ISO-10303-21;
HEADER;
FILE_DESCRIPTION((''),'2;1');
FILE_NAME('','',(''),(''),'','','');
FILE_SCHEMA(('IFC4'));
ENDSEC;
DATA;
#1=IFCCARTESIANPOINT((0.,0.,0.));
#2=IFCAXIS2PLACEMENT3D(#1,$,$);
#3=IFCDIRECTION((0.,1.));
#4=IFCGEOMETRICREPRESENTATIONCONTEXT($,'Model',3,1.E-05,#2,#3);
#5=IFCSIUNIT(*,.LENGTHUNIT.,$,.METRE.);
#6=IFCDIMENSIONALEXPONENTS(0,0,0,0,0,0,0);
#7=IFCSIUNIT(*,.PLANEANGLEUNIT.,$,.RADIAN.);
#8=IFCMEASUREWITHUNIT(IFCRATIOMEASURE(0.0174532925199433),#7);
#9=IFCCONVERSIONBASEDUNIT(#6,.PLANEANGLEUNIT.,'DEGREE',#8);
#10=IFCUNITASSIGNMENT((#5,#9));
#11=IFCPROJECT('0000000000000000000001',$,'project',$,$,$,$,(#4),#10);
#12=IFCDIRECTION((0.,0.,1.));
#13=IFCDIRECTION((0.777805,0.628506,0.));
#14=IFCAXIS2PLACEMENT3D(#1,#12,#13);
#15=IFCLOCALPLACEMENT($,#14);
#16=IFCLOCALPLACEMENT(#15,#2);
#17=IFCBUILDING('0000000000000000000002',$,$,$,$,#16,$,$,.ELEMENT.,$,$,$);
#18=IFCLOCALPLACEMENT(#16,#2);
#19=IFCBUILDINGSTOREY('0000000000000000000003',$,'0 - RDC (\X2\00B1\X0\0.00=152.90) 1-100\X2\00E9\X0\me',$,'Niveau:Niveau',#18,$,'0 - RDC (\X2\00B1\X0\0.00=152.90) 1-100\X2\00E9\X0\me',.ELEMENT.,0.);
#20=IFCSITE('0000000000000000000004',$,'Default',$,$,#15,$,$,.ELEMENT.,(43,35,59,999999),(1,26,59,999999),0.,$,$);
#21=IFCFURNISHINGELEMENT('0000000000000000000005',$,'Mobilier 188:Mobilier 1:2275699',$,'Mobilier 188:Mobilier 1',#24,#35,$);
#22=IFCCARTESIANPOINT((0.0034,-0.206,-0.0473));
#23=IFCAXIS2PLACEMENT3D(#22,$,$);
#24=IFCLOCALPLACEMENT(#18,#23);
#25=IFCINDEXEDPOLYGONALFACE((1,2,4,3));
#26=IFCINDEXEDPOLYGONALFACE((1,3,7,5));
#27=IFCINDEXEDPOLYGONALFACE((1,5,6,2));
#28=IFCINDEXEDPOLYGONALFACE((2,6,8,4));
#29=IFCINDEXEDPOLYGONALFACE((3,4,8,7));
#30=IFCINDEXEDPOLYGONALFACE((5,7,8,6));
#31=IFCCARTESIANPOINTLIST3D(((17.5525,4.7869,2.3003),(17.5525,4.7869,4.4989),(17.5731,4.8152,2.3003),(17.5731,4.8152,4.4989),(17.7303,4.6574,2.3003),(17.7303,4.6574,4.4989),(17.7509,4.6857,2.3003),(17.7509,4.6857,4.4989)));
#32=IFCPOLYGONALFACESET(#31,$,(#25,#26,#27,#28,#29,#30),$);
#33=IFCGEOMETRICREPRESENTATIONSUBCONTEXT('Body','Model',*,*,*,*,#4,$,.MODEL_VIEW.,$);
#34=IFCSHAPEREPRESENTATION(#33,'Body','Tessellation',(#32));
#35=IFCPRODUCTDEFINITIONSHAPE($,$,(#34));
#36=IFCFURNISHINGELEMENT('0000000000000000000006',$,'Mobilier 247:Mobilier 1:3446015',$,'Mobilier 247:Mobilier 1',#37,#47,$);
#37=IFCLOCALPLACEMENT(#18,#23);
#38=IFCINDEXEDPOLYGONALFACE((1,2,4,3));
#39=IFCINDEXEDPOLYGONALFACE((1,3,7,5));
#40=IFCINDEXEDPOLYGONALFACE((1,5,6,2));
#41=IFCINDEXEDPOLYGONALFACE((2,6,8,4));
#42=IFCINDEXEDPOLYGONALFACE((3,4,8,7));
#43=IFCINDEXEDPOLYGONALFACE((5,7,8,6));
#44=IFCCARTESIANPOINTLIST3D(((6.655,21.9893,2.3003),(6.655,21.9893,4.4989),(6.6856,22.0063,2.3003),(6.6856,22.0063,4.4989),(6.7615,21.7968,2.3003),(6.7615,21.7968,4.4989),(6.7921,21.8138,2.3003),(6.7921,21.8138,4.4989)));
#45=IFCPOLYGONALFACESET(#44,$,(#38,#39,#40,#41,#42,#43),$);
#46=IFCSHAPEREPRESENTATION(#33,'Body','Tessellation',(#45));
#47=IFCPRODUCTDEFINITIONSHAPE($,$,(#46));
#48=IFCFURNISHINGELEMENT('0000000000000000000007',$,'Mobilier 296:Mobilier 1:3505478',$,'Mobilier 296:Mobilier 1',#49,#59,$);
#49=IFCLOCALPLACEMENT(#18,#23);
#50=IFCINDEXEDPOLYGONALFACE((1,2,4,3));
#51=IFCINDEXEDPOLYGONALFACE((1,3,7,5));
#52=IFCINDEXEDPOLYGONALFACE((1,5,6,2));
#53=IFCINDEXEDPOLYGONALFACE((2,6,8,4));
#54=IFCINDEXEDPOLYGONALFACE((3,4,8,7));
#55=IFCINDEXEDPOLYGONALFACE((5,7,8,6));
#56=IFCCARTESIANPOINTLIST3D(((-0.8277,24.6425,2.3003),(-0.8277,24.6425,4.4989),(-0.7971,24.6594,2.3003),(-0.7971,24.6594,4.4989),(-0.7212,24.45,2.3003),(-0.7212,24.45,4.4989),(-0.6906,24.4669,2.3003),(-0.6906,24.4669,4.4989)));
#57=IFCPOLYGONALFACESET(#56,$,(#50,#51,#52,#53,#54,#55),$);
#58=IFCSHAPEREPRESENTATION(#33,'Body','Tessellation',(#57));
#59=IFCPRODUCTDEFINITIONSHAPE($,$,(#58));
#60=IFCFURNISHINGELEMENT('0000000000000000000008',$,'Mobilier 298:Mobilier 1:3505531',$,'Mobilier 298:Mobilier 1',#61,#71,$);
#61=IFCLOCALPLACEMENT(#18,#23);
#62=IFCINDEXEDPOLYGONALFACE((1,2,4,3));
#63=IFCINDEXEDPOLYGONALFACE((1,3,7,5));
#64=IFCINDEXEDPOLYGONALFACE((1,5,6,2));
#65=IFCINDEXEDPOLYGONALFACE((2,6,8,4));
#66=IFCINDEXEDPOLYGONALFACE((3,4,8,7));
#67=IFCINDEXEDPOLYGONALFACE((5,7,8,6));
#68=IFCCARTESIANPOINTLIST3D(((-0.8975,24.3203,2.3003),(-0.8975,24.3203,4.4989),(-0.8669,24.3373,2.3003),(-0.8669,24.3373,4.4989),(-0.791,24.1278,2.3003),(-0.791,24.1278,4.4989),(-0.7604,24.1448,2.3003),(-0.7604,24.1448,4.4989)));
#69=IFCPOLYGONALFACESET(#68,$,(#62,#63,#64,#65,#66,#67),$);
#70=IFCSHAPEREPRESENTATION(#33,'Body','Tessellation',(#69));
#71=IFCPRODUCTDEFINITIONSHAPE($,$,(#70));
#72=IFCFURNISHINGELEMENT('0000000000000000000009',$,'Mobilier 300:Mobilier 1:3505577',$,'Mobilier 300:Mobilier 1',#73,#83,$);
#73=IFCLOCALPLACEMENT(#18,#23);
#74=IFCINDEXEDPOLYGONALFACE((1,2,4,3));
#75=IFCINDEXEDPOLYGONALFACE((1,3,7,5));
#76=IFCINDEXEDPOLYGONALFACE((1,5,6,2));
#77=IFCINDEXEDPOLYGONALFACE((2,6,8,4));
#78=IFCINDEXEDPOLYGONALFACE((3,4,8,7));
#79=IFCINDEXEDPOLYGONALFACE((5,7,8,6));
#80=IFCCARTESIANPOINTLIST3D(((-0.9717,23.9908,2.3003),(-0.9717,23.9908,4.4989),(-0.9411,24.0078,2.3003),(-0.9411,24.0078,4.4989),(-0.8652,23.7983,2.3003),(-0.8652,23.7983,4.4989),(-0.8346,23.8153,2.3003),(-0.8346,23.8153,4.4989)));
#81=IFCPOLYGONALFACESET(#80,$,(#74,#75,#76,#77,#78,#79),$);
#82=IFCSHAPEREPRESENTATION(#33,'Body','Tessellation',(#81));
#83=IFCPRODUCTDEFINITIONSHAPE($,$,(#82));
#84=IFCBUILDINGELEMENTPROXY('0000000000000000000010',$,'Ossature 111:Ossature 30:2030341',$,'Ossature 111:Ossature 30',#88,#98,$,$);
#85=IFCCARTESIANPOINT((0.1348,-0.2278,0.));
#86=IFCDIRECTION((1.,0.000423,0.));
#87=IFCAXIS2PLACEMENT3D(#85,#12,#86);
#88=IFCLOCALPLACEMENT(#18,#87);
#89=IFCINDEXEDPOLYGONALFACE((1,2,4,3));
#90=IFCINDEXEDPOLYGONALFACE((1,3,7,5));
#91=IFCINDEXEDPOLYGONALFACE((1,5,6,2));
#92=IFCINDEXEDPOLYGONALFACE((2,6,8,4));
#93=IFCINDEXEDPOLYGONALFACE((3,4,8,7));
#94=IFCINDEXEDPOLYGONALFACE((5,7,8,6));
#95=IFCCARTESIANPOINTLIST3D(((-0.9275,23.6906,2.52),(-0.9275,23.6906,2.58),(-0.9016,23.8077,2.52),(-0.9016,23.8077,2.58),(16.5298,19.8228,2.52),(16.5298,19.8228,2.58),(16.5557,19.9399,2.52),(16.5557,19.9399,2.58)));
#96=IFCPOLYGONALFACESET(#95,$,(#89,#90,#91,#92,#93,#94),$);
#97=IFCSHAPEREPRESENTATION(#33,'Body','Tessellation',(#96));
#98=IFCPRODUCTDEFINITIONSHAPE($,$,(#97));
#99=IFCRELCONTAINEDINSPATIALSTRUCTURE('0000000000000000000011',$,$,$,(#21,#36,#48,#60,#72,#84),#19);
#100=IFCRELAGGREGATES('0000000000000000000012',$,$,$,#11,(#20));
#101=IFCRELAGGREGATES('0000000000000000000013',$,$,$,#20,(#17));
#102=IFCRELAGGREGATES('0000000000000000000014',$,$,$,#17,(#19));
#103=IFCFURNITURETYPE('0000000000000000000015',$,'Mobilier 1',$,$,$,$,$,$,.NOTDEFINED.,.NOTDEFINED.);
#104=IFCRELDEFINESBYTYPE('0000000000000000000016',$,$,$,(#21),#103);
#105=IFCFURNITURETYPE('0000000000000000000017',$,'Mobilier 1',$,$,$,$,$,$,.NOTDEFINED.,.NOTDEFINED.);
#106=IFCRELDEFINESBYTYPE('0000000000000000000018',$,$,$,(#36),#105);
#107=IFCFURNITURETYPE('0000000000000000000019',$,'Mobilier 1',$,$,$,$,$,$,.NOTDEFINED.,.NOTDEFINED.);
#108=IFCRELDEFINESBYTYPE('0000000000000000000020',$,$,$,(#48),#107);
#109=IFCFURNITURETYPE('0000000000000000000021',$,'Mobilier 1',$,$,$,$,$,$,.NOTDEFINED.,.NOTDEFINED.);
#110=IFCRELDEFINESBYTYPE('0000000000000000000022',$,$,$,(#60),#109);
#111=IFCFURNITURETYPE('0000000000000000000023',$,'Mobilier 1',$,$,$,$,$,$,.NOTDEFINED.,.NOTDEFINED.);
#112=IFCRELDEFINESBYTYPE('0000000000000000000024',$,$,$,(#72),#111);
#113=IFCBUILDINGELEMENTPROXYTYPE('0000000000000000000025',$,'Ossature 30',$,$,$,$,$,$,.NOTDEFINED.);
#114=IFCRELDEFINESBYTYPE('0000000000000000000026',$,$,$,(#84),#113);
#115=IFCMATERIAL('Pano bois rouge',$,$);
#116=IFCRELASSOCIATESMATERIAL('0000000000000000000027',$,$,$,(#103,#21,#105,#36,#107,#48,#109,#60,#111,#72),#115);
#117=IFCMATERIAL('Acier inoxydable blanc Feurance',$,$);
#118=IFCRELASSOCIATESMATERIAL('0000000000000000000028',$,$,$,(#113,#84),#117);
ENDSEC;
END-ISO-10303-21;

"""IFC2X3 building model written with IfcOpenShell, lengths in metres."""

from ifc_helpers import new_model, entity, si_unit, converted_unit, direction, frame, frame_2d, origin, origin_2d_with_axis, place, context, subcontext, project, spatial, rectangle, extrude, source, transform, mapped, material, type_object, type_shapes, element, save


model = new_model("IFC2X3")

# Units and contexts
model_context = context("Model", 3, precision=1e-05, world=origin(), true_north=direction((0.0, 1.0)))
body_context = subcontext(model_context, "Body", "Model", "MODEL_VIEW")
ifc_project = project(units=[si_unit("LENGTHUNIT", "METRE"), converted_unit("PLANEANGLEUNIT", "DEGREE", entity("IfcRatioMeasure", 0.0174532925199433), si_unit("PLANEANGLEUNIT", "RADIAN"), dimensions=[0, 0, 0, 0, 0, 0, 0])], contexts=[model_context])

# Site, building, storey
site_placement = place(None, frame((0.0, 0.0, 0.0), z_axis=(0.0, 0.0, 1.0), x_axis=(0.777805, 0.628506, 0.0)))
site = spatial("IfcSite", under=ifc_project, at=site_placement, Name="Default", CompositionType="ELEMENT", RefLatitude=(43, 35, 59, 999999), RefLongitude=(1, 26, 59, 999999), RefElevation=0.0)
building_placement = place(site_placement, origin())
building = spatial("IfcBuilding", under=site, at=building_placement, CompositionType="ELEMENT")
storey_placement = place(building_placement, origin())
storey = spatial("IfcBuildingStorey", under=building, at=storey_placement, Name="0 - RDC (±0.00=152.90) 1-100éme", ObjectType="Niveau:Niveau", LongName="0 - RDC (±0.00=152.90) 1-100éme", CompositionType="ELEMENT", Elevation=0.0)

# Furnishing elements
ifc_material_1 = material(Name="Pano bois rouge")
furniture_type_1 = type_object("IfcFurnitureType", Name="Mobilier 1", material=ifc_material_1)
shared_shape_1 = source(origin(), body_context, "Body", "SweptSolid", [
    extrude(rectangle(XDim=0.035, YDim=0.22, at=frame_2d((0.0, 0.0), x_axis=(1.0, 0.0))), frame((17.6517, 4.7363, 2.3003), z_axis=(0.0, 0.0, 1.0), x_axis=(-0.588424, -0.808553, 0.0)), (0.0, 0.0, 1.0), 2.1986),
])
type_shapes(furniture_type_1, [shared_shape_1])
furnishing_1_placement = place(storey_placement, frame((0.0034, -0.206, -0.0473)))
element("IfcFurnishingElement", 1, at=furnishing_1_placement, inside=storey, type_object=furniture_type_1, material=ifc_material_1, Name="Mobilier 188:Mobilier 1:2275699", ObjectType="Mobilier 188:Mobilier 1", context=body_context, shape_type="MappedRepresentation", body=[
    mapped(shared_shape_1, transform((0.0, 0.0, 0.0), scale=1.0)),
])
furniture_type_2 = type_object("IfcFurnitureType", Name="Mobilier 1", material=ifc_material_1)
shared_shape_2 = source(origin(), body_context, "Body", "SweptSolid", [
    extrude(rectangle(XDim=0.035, YDim=0.22, at=origin_2d_with_axis()), frame((6.7235, 21.9016, 2.3003), z_axis=(0.0, 0.0, 1.0), x_axis=(-0.875002, -0.484119, 0.0)), (0.0, 0.0, 1.0), 2.1986),
])
type_shapes(furniture_type_2, [shared_shape_2])
furnishing_2_placement = place(storey_placement, frame((0.0034, -0.206, -0.0473)))
element("IfcFurnishingElement", 2, at=furnishing_2_placement, inside=storey, type_object=furniture_type_2, material=ifc_material_1, Name="Mobilier 247:Mobilier 1:3446015", ObjectType="Mobilier 247:Mobilier 1", context=body_context, shape_type="MappedRepresentation", body=[
    mapped(shared_shape_2, transform((0.0, 0.0, 0.0), scale=1.0)),
])
furniture_type_3 = type_object("IfcFurnitureType", Name="Mobilier 1", material=ifc_material_1)
shared_shape_3 = source(origin(), body_context, "Body", "SweptSolid", [
    extrude(rectangle(XDim=0.035, YDim=0.22, at=frame_2d((0.0, 0.0), x_axis=(1.0, 0.0))), frame((-0.7592, 24.5547, 2.3003), z_axis=(0.0, 0.0, 1.0), x_axis=(-0.875002, -0.484119, 0.0)), (0.0, 0.0, 1.0), 2.1986),
])
type_shapes(furniture_type_3, [shared_shape_3])
furnishing_3_placement = place(storey_placement, frame((0.0034, -0.206, -0.0473)))
element("IfcFurnishingElement", 3, at=furnishing_3_placement, inside=storey, type_object=furniture_type_3, material=ifc_material_1, Name="Mobilier 296:Mobilier 1:3505478", ObjectType="Mobilier 296:Mobilier 1", context=body_context, shape_type="MappedRepresentation", body=[
    mapped(shared_shape_3, transform((0.0, 0.0, 0.0), scale=1.0)),
])
furniture_type_4 = type_object("IfcFurnitureType", Name="Mobilier 1", material=ifc_material_1)
shared_shape_4 = source(origin(), body_context, "Body", "SweptSolid", [
    extrude(rectangle(XDim=0.035, YDim=0.22, at=frame_2d((0.0, 0.0), x_axis=(1.0, 0.0))), frame((-0.829, 24.2325, 2.3003), z_axis=(0.0, 0.0, 1.0), x_axis=(-0.875002, -0.484119, 0.0)), (0.0, 0.0, 1.0), 2.1986),
])
type_shapes(furniture_type_4, [shared_shape_4])
furnishing_4_placement = place(storey_placement, frame((0.0034, -0.206, -0.0473)))
element("IfcFurnishingElement", 4, at=furnishing_4_placement, inside=storey, type_object=furniture_type_4, material=ifc_material_1, Name="Mobilier 298:Mobilier 1:3505531", ObjectType="Mobilier 298:Mobilier 1", context=body_context, shape_type="MappedRepresentation", body=[
    mapped(shared_shape_4, transform((0.0, 0.0, 0.0), scale=1.0)),
])
furniture_type_5 = type_object("IfcFurnitureType", Name="Mobilier 1", material=ifc_material_1)
shared_shape_5 = source(origin(), body_context, "Body", "SweptSolid", [
    extrude(rectangle(XDim=0.035, YDim=0.22, at=frame_2d((0.0, 0.0), x_axis=(1.0, 0.0))), frame((-0.9032, 23.9031, 2.3003), z_axis=(0.0, 0.0, 1.0), x_axis=(-0.875002, -0.484119, 0.0)), (0.0, 0.0, 1.0), 2.1986),
])
type_shapes(furniture_type_5, [shared_shape_5])
furnishing_5_placement = place(storey_placement, frame((0.0034, -0.206, -0.0473)))
element("IfcFurnishingElement", 5, at=furnishing_5_placement, inside=storey, type_object=furniture_type_5, material=ifc_material_1, Name="Mobilier 300:Mobilier 1:3505577", ObjectType="Mobilier 300:Mobilier 1", context=body_context, shape_type="MappedRepresentation", body=[
    mapped(shared_shape_5, transform((0.0, 0.0, 0.0), scale=1.0)),
])

# Building element proxy
ifc_material_2 = material(Name="Acier inoxydable blanc Feurance")
building_element_proxy_type = type_object("IfcBuildingElementProxyType", Name="Ossature 30", PredefinedType="NOTDEFINED", material=ifc_material_2)
shared_shape_6 = source(origin(), body_context, "Body", "SweptSolid", [
    extrude(rectangle(XDim=17.8806, YDim=0.12, at=frame_2d((0.0, 0.0), x_axis=(1.0, 0.0))), frame((7.8141, 21.8152, 2.52), z_axis=(0.0, 0.0, 1.0), x_axis=(0.976324, -0.216314, 0.0)), (0.0, 0.0, 1.0), 0.06),
])
type_shapes(building_element_proxy_type, [shared_shape_6])
proxy_placement = place(storey_placement, frame((0.1348, -0.2278, 0.0), z_axis=(0.0, 0.0, 1.0), x_axis=(1.0, 0.000423, 0.0)))
element("IfcBuildingElementProxy", 6, at=proxy_placement, inside=storey, type_object=building_element_proxy_type, material=ifc_material_2, Name="Ossature 111:Ossature 30:2030341", ObjectType="Ossature 111:Ossature 30", context=body_context, shape_type="MappedRepresentation", body=[
    mapped(shared_shape_6, transform((0.0, 0.0, 0.0), scale=1.0)),
])

save(model, "model.ifc")
